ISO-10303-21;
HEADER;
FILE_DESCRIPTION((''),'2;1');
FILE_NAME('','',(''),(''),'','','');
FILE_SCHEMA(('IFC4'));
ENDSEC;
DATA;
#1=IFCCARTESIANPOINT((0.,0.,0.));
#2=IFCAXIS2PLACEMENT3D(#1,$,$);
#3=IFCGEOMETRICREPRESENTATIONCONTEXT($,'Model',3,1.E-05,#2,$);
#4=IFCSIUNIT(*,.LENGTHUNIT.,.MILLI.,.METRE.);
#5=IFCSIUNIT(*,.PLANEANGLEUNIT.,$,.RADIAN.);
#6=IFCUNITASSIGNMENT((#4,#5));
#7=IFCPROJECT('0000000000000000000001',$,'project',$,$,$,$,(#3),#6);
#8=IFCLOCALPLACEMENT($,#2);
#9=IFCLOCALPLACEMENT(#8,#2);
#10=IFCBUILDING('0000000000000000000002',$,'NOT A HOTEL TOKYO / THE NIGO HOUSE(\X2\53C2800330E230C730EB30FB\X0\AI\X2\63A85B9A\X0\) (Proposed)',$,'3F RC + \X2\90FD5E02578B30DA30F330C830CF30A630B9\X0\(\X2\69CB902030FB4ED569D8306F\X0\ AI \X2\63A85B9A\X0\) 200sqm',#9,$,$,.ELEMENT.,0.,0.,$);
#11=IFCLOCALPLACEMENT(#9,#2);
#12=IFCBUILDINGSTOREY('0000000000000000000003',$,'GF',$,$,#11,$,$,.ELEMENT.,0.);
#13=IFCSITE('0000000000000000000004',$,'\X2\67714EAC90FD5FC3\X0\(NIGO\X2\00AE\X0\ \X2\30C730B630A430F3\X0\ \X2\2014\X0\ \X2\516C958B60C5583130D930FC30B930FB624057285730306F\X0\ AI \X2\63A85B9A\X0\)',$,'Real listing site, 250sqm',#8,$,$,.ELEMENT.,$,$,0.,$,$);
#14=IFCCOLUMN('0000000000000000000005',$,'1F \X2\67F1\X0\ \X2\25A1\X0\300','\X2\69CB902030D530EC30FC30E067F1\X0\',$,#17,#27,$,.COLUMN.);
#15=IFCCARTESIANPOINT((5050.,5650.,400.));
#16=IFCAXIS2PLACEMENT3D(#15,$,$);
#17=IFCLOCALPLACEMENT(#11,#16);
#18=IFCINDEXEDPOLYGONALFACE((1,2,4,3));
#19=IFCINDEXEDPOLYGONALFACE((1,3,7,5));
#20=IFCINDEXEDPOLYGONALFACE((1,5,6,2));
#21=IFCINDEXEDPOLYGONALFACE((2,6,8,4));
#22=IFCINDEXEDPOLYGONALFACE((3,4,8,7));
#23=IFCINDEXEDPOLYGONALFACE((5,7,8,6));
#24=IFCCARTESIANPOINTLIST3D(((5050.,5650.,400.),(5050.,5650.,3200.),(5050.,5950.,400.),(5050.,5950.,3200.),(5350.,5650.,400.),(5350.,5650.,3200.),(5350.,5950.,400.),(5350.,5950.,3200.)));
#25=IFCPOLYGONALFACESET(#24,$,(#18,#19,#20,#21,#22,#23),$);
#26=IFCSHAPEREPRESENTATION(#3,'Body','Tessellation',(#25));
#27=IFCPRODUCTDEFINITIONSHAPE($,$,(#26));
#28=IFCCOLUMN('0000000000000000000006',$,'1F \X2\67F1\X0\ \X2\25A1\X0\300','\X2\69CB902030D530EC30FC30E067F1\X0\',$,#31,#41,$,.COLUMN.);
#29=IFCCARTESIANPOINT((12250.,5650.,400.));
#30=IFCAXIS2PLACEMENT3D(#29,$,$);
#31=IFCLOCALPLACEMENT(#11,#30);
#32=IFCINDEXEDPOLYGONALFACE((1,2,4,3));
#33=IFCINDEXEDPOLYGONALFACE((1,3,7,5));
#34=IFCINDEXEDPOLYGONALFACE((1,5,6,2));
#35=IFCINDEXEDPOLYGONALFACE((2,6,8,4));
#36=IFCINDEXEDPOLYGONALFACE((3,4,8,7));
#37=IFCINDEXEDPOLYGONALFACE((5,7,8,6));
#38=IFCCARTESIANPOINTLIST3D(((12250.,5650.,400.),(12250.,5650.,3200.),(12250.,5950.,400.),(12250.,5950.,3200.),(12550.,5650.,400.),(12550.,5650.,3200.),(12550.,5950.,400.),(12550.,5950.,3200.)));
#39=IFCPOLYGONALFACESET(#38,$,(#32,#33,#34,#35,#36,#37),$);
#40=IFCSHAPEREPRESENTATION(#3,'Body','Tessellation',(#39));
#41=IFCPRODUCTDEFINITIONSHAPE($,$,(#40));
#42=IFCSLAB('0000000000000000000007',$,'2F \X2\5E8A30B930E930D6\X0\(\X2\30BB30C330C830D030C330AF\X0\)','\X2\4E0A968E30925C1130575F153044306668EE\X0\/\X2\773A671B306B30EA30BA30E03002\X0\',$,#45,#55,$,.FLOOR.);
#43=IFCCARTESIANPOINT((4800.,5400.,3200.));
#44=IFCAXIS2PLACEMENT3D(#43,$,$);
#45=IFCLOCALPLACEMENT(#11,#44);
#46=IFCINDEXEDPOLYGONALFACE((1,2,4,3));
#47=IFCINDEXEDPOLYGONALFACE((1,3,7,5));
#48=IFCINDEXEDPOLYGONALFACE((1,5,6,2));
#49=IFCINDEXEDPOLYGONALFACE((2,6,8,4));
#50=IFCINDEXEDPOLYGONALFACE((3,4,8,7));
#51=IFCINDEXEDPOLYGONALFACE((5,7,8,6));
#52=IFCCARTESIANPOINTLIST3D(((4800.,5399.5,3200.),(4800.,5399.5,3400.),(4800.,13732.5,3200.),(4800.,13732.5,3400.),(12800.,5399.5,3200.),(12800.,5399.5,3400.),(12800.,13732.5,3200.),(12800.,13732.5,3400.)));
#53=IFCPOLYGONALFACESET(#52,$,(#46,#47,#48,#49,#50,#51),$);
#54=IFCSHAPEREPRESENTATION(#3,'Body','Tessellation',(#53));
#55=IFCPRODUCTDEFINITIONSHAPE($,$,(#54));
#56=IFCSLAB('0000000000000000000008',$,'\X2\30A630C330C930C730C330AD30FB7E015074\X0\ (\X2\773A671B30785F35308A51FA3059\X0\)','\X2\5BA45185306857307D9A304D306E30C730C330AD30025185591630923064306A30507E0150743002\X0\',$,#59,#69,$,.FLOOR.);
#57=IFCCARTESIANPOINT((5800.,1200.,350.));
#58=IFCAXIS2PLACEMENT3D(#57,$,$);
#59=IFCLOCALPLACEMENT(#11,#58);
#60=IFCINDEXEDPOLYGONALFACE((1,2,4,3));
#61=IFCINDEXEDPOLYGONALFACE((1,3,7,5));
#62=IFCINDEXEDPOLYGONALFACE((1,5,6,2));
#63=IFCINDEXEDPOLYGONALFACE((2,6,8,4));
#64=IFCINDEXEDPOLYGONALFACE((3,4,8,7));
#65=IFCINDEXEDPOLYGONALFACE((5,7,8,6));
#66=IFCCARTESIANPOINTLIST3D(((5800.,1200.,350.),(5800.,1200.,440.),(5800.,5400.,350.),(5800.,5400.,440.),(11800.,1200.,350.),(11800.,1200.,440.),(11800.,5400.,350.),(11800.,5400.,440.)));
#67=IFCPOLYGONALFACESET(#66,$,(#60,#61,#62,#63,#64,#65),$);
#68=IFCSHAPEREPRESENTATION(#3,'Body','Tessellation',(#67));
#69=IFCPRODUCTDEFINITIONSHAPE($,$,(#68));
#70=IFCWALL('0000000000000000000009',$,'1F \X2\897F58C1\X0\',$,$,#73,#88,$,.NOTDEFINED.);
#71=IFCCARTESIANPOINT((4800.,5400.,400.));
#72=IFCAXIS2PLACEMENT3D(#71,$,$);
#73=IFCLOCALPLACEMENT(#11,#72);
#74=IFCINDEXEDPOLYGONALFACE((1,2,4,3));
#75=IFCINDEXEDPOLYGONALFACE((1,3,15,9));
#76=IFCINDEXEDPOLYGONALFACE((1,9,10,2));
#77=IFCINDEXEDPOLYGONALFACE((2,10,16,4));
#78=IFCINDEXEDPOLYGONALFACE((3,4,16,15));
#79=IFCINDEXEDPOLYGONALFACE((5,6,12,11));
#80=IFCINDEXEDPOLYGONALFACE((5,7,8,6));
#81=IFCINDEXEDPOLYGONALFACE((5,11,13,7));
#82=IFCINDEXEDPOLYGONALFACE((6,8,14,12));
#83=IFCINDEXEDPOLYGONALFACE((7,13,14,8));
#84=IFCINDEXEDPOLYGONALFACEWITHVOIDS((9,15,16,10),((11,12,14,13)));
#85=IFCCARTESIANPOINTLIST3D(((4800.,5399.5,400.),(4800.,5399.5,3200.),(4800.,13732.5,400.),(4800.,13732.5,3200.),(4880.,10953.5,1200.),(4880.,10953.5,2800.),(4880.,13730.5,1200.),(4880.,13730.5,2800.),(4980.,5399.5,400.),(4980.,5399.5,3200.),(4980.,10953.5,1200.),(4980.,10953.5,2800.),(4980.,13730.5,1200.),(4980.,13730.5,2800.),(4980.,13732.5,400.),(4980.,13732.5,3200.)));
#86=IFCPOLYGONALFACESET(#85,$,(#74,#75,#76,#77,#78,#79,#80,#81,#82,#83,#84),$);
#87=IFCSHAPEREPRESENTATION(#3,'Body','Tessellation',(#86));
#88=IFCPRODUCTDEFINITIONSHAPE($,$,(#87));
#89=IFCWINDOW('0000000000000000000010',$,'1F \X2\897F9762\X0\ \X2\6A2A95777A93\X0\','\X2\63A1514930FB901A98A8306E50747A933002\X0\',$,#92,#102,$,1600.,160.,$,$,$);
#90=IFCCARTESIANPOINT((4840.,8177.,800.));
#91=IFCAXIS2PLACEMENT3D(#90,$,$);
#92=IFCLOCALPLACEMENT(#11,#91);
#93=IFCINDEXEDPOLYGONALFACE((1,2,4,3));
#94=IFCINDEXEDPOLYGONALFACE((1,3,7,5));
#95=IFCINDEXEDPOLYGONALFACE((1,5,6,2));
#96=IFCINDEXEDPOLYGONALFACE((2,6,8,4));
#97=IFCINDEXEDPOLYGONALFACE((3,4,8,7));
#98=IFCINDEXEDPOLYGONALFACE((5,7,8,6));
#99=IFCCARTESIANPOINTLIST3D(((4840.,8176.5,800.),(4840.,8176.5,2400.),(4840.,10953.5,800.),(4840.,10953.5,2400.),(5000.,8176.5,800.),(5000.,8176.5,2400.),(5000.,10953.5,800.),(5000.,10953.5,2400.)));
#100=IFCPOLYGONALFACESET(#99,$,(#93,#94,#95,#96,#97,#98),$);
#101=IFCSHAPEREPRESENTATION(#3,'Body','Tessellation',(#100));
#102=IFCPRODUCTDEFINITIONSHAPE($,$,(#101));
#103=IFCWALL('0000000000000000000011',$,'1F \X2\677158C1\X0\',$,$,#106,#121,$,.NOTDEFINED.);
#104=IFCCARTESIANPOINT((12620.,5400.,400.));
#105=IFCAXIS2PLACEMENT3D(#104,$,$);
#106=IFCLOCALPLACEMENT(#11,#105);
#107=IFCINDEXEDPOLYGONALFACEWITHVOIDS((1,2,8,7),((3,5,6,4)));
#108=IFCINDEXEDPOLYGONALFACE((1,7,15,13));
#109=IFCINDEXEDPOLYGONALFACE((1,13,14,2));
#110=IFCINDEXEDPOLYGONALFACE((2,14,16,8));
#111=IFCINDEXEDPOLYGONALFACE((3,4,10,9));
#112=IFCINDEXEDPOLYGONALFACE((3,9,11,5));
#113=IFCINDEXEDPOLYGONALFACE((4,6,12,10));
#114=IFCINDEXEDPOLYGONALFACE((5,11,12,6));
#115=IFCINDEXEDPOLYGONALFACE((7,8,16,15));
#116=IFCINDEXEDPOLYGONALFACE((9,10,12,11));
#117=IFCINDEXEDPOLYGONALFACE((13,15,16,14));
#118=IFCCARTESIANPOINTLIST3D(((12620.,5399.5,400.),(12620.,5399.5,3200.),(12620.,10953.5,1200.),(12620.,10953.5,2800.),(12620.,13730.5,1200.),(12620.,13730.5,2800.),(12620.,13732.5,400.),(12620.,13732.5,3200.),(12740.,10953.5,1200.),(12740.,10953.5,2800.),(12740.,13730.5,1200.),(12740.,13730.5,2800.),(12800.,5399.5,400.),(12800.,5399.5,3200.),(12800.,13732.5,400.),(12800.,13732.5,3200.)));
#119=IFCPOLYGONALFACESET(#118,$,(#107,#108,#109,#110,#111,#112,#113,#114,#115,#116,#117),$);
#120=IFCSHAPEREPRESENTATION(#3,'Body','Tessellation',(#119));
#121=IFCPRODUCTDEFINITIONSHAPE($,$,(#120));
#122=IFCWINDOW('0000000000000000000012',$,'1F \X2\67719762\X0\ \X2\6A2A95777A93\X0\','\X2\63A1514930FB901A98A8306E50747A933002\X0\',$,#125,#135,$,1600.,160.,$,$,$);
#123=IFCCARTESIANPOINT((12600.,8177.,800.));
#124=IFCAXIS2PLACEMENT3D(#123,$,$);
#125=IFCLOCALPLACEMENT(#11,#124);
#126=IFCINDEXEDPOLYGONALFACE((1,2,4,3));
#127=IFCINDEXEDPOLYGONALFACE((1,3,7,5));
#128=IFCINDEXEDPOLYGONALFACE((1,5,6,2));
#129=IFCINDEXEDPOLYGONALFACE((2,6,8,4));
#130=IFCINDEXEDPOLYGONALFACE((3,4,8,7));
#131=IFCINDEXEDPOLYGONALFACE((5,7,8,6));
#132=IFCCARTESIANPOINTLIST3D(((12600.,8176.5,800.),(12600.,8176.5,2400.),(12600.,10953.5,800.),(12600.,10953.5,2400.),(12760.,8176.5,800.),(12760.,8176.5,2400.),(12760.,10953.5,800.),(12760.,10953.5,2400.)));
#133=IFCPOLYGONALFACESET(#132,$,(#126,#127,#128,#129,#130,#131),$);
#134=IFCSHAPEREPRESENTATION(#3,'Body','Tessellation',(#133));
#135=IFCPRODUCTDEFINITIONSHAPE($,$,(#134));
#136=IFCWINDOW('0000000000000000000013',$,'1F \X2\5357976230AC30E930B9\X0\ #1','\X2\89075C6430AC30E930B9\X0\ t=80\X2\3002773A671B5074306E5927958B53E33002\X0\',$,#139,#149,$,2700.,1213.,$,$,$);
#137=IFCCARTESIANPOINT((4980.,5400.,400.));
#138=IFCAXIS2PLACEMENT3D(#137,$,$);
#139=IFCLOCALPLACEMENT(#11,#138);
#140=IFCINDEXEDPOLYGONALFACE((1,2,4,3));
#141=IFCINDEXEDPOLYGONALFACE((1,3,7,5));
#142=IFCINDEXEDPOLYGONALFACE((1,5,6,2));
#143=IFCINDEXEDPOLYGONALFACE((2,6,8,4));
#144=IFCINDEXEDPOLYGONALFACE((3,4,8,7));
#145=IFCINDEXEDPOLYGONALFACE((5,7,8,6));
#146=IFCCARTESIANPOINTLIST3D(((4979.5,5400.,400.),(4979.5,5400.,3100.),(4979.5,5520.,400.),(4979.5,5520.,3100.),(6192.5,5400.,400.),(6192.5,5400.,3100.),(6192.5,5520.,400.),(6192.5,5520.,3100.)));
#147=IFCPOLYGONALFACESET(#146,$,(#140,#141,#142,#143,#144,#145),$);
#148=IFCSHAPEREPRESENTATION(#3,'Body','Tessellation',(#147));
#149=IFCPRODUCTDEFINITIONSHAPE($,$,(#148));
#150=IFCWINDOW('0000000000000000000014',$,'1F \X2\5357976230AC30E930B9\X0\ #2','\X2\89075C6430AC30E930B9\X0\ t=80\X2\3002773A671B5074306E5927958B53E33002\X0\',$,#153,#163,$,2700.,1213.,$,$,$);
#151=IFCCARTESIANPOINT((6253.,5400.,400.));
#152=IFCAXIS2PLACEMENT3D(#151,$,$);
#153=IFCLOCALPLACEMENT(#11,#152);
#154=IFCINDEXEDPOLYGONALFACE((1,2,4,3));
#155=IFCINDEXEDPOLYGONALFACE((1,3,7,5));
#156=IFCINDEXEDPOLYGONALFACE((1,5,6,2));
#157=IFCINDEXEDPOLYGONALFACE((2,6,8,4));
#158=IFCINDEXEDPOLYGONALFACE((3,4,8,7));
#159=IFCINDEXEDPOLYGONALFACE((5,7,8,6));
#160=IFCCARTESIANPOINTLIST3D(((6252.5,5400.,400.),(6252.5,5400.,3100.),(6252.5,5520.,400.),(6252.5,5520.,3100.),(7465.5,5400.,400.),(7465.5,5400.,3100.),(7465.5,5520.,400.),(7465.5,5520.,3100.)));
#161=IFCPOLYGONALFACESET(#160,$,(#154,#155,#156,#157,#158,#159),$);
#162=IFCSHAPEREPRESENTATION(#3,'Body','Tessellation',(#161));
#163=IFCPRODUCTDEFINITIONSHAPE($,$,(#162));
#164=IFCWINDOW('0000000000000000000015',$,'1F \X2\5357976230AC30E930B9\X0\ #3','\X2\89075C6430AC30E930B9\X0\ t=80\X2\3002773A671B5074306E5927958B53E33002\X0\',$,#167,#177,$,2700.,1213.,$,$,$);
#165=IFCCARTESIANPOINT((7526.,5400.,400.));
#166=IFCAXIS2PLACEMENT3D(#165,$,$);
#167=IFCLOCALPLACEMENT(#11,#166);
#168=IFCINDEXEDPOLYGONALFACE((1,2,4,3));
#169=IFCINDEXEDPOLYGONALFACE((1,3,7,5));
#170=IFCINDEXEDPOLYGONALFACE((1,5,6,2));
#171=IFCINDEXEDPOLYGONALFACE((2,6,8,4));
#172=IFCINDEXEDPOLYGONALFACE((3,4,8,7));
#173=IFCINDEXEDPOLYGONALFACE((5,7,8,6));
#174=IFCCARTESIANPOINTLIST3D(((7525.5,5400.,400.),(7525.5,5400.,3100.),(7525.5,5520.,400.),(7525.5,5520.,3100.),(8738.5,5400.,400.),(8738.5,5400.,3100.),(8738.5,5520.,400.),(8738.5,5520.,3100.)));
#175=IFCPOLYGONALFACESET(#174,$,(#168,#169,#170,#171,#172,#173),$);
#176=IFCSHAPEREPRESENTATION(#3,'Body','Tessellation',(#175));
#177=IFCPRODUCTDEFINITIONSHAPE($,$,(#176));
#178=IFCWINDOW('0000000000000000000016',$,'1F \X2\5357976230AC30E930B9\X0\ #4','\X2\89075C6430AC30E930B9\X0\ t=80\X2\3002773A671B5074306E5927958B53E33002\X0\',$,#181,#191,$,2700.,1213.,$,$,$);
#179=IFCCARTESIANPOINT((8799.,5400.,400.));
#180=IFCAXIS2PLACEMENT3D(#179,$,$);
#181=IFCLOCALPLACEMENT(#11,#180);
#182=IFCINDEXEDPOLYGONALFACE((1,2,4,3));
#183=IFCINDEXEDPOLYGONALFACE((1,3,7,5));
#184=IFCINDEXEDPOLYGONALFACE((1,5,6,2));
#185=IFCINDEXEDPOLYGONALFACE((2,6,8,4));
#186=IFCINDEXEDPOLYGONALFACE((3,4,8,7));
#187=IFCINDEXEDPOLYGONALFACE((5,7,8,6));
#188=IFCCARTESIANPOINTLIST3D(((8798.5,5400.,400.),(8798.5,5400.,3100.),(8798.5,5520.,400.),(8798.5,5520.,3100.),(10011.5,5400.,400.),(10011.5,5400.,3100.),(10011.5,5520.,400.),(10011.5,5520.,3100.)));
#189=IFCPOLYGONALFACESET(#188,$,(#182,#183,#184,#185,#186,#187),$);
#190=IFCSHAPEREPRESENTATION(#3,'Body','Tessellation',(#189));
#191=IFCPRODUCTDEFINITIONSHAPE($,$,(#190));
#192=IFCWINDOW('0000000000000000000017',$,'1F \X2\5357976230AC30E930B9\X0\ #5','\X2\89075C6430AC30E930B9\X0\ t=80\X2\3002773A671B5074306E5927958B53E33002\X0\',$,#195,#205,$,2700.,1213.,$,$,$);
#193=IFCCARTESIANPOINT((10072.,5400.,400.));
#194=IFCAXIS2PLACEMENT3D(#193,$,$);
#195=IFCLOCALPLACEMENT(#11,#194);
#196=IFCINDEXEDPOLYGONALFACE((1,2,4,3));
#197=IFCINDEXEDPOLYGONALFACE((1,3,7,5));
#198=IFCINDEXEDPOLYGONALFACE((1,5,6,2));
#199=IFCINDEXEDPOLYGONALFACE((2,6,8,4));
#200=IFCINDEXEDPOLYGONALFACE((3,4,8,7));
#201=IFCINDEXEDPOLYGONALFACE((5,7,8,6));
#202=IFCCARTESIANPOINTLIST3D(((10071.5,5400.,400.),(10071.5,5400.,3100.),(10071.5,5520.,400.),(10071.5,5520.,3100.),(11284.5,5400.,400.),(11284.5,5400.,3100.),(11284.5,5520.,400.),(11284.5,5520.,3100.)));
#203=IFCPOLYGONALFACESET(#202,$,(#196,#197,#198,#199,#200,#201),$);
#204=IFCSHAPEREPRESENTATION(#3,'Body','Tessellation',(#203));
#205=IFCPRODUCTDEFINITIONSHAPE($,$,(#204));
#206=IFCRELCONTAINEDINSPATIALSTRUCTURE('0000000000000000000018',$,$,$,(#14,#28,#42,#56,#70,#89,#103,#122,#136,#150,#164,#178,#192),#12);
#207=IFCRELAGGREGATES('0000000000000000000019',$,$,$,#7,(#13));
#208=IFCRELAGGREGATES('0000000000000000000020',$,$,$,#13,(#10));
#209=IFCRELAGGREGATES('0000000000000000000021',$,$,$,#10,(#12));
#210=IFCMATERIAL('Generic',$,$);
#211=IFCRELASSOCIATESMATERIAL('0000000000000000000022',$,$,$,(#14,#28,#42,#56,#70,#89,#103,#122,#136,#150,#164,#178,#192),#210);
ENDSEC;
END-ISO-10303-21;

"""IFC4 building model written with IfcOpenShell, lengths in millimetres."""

from ifc_helpers import new_model, si_unit, frame, frame_2d, origin, place, context, project, spatial, rectangle, extrude, material, element, fill, save


model = new_model("IFC4")

# Units and contexts
model_context = context("Model", 3, precision=1e-05, world=origin())
ifc_project = project(units=[si_unit("LENGTHUNIT", "METRE", prefix="MILLI"), si_unit("PLANEANGLEUNIT", "RADIAN")], contexts=[model_context])

# Site, building, storey
site_placement = place(None, origin())
site = spatial("IfcSite", under=ifc_project, at=site_placement, Name="東京都心(NIGO® デザイン — 公開情報ベース・所在地は AI 推定)", ObjectType="Real listing site, 250sqm", CompositionType="ELEMENT", RefElevation=0.0)
building_placement = place(site_placement, origin())
building = spatial("IfcBuilding", under=site, at=building_placement, Name="NOT A HOTEL TOKYO / THE NIGO HOUSE(参考モデル・AI推定) (Proposed)", ObjectType="3F RC + 都市型ペントハウス(構造・仕様は AI 推定) 200sqm", CompositionType="ELEMENT", ElevationOfRefHeight=0.0, ElevationOfTerrain=0.0)
storey_placement = place(building_placement, origin())
storey = spatial("IfcBuildingStorey", under=building, at=storey_placement, Name="GF", CompositionType="ELEMENT", Elevation=0.0)

# Columns
ifc_material_1 = material(Name="Generic")
column_1_placement = place(storey_placement, frame((5050.0, 5650.0, 400.0)))
element("IfcColumn", 1, at=column_1_placement, inside=storey, material=ifc_material_1, Name="1F 柱 □300", Description="構造フレーム柱", PredefinedType="COLUMN", context=model_context, shape_type="SweptSolid", body=[
    extrude(rectangle(XDim=300.0, YDim=300.0, at=frame_2d((150.0, 150.0))), frame((5050.0, 5650.0, 400.0)), (0.0, 0.0, 1.0), 2800.0),
])
column_2_placement = place(storey_placement, frame((12250.0, 5650.0, 400.0)))
element("IfcColumn", 2, at=column_2_placement, inside=storey, material=ifc_material_1, Name="1F 柱 □300", Description="構造フレーム柱", PredefinedType="COLUMN", context=model_context, shape_type="SweptSolid", body=[
    extrude(rectangle(XDim=300.0, YDim=300.0, at=frame_2d((150.0, 150.0))), frame((12250.0, 5650.0, 400.0)), (0.0, 0.0, 1.0), 2800.0),
])

# Slabs
slab_1_placement = place(storey_placement, frame((4800.0, 5400.0, 3200.0)))
element("IfcSlab", 3, at=slab_1_placement, inside=storey, material=ifc_material_1, Name="2F 床スラブ(セットバック)", Description="上階を少し引いて森/眺望にリズム。", PredefinedType="FLOOR", context=model_context, shape_type="SweptSolid", body=[
    extrude(rectangle(XDim=8000.0, YDim=8333.0, at=frame_2d((4000.0, 4166.0))), frame((4800.0, 5400.0, 3200.0)), (0.0, 0.0, 1.0), 200.0),
])
slab_2_placement = place(storey_placement, frame((5800.0, 1200.0, 350.0)))
element("IfcSlab", 4, at=slab_2_placement, inside=storey, material=ifc_material_1, Name="ウッドデッキ・縁側 (眺望へ張り出す)", Description="室内と地続きのデッキ。内外をつなぐ縁側。", PredefinedType="FLOOR", context=model_context, shape_type="SweptSolid", body=[
    extrude(rectangle(XDim=6000.0, YDim=4200.0, at=frame_2d((3000.0, 2100.0))), frame((5800.0, 1200.0, 350.0)), (0.0, 0.0, 1.0), 90.0),
])

# Walls, openings, windows
wall_1_placement = place(storey_placement, frame((4800.0, 5400.0, 400.0)))
wall_1 = element("IfcWall", 5, at=wall_1_placement, inside=storey, material=ifc_material_1, Name="1F 西壁", PredefinedType="NOTDEFINED", context=model_context, shape_type="SweptSolid", body=[
    extrude(rectangle(XDim=180.0, YDim=8333.0, at=frame_2d((90.0, 4166.0))), frame((4800.0, 5400.0, 400.0)), (0.0, 0.0, 1.0), 2800.0),
])
opening_1_placement = place(storey_placement, frame((4840.0, 8177.0, 800.0)))
opening_1 = element("IfcOpeningElement", 6, at=opening_1_placement, cuts=wall_1, PredefinedType="NOTDEFINED", context=model_context, shape_type="SweptSolid", body=[
    extrude(rectangle(XDim=160.0, YDim=2777.0, at=frame_2d((80.0, 1388.0))), frame((4840.0, 8177.0, 800.0)), (0.0, 0.0, 1.0), 1600.0),
])
window_1_placement = place(storey_placement, frame((4840.0, 8177.0, 800.0)))
window_1 = element("IfcWindow", 7, at=window_1_placement, inside=storey, material=ifc_material_1, Name="1F 西面 横長窓", Description="採光・通風の側窓。", OverallHeight=1600.0, OverallWidth=160.0, context=model_context, shape_type="SweptSolid", body=[
    extrude(rectangle(XDim=160.0, YDim=2777.0, at=frame_2d((80.0, 1388.0))), frame((4840.0, 8177.0, 800.0)), (0.0, 0.0, 1.0), 1600.0),
])
fill(opening_1, window_1)
wall_2_placement = place(storey_placement, frame((12620.0, 5400.0, 400.0)))
wall_2 = element("IfcWall", 8, at=wall_2_placement, inside=storey, material=ifc_material_1, Name="1F 東壁", PredefinedType="NOTDEFINED", context=model_context, shape_type="SweptSolid", body=[
    extrude(rectangle(XDim=180.0, YDim=8333.0, at=frame_2d((90.0, 4166.0))), frame((12620.0, 5400.0, 400.0)), (0.0, 0.0, 1.0), 2800.0),
])
opening_2_placement = place(storey_placement, frame((12600.0, 8177.0, 800.0)))
opening_2 = element("IfcOpeningElement", 9, at=opening_2_placement, cuts=wall_2, PredefinedType="NOTDEFINED", context=model_context, shape_type="SweptSolid", body=[
    extrude(rectangle(XDim=160.0, YDim=2777.0, at=frame_2d((80.0, 1388.0))), frame((12600.0, 8177.0, 800.0)), (0.0, 0.0, 1.0), 1600.0),
])
window_2_placement = place(storey_placement, frame((12600.0, 8177.0, 800.0)))
window_2 = element("IfcWindow", 10, at=window_2_placement, inside=storey, material=ifc_material_1, Name="1F 東面 横長窓", Description="採光・通風の側窓。", OverallHeight=1600.0, OverallWidth=160.0, context=model_context, shape_type="SweptSolid", body=[
    extrude(rectangle(XDim=160.0, YDim=2777.0, at=frame_2d((80.0, 1388.0))), frame((12600.0, 8177.0, 800.0)), (0.0, 0.0, 1.0), 1600.0),
])
fill(opening_2, window_2)

# Windows
window_3_placement = place(storey_placement, frame((4980.0, 5400.0, 400.0)))
element("IfcWindow", 11, at=window_3_placement, inside=storey, material=ifc_material_1, Name="1F 南面ガラス #1", Description="複層ガラス t=80。眺望側の大開口。", OverallHeight=2700.0, OverallWidth=1213.0, context=model_context, shape_type="SweptSolid", body=[
    extrude(rectangle(XDim=1213.0, YDim=120.0, at=frame_2d((606.0, 60.0))), frame((4980.0, 5400.0, 400.0)), (0.0, 0.0, 1.0), 2700.0),
])
window_4_placement = place(storey_placement, frame((6253.0, 5400.0, 400.0)))
element("IfcWindow", 12, at=window_4_placement, inside=storey, material=ifc_material_1, Name="1F 南面ガラス #2", Description="複層ガラス t=80。眺望側の大開口。", OverallHeight=2700.0, OverallWidth=1213.0, context=model_context, shape_type="SweptSolid", body=[
    extrude(rectangle(XDim=1213.0, YDim=120.0, at=frame_2d((606.0, 60.0))), frame((6253.0, 5400.0, 400.0)), (0.0, 0.0, 1.0), 2700.0),
])
window_5_placement = place(storey_placement, frame((7526.0, 5400.0, 400.0)))
element("IfcWindow", 13, at=window_5_placement, inside=storey, material=ifc_material_1, Name="1F 南面ガラス #3", Description="複層ガラス t=80。眺望側の大開口。", OverallHeight=2700.0, OverallWidth=1213.0, context=model_context, shape_type="SweptSolid", body=[
    extrude(rectangle(XDim=1213.0, YDim=120.0, at=frame_2d((606.0, 60.0))), frame((7526.0, 5400.0, 400.0)), (0.0, 0.0, 1.0), 2700.0),
])
window_6_placement = place(storey_placement, frame((8799.0, 5400.0, 400.0)))
element("IfcWindow", 14, at=window_6_placement, inside=storey, material=ifc_material_1, Name="1F 南面ガラス #4", Description="複層ガラス t=80。眺望側の大開口。", OverallHeight=2700.0, OverallWidth=1213.0, context=model_context, shape_type="SweptSolid", body=[
    extrude(rectangle(XDim=1213.0, YDim=120.0, at=frame_2d((606.0, 60.0))), frame((8799.0, 5400.0, 400.0)), (0.0, 0.0, 1.0), 2700.0),
])
window_7_placement = place(storey_placement, frame((10072.0, 5400.0, 400.0)))
element("IfcWindow", 15, at=window_7_placement, inside=storey, material=ifc_material_1, Name="1F 南面ガラス #5", Description="複層ガラス t=80。眺望側の大開口。", OverallHeight=2700.0, OverallWidth=1213.0, context=model_context, shape_type="SweptSolid", body=[
    extrude(rectangle(XDim=1213.0, YDim=120.0, at=frame_2d((606.0, 60.0))), frame((10072.0, 5400.0, 400.0)), (0.0, 0.0, 1.0), 2700.0),
])

save(model, "model.ifc")
